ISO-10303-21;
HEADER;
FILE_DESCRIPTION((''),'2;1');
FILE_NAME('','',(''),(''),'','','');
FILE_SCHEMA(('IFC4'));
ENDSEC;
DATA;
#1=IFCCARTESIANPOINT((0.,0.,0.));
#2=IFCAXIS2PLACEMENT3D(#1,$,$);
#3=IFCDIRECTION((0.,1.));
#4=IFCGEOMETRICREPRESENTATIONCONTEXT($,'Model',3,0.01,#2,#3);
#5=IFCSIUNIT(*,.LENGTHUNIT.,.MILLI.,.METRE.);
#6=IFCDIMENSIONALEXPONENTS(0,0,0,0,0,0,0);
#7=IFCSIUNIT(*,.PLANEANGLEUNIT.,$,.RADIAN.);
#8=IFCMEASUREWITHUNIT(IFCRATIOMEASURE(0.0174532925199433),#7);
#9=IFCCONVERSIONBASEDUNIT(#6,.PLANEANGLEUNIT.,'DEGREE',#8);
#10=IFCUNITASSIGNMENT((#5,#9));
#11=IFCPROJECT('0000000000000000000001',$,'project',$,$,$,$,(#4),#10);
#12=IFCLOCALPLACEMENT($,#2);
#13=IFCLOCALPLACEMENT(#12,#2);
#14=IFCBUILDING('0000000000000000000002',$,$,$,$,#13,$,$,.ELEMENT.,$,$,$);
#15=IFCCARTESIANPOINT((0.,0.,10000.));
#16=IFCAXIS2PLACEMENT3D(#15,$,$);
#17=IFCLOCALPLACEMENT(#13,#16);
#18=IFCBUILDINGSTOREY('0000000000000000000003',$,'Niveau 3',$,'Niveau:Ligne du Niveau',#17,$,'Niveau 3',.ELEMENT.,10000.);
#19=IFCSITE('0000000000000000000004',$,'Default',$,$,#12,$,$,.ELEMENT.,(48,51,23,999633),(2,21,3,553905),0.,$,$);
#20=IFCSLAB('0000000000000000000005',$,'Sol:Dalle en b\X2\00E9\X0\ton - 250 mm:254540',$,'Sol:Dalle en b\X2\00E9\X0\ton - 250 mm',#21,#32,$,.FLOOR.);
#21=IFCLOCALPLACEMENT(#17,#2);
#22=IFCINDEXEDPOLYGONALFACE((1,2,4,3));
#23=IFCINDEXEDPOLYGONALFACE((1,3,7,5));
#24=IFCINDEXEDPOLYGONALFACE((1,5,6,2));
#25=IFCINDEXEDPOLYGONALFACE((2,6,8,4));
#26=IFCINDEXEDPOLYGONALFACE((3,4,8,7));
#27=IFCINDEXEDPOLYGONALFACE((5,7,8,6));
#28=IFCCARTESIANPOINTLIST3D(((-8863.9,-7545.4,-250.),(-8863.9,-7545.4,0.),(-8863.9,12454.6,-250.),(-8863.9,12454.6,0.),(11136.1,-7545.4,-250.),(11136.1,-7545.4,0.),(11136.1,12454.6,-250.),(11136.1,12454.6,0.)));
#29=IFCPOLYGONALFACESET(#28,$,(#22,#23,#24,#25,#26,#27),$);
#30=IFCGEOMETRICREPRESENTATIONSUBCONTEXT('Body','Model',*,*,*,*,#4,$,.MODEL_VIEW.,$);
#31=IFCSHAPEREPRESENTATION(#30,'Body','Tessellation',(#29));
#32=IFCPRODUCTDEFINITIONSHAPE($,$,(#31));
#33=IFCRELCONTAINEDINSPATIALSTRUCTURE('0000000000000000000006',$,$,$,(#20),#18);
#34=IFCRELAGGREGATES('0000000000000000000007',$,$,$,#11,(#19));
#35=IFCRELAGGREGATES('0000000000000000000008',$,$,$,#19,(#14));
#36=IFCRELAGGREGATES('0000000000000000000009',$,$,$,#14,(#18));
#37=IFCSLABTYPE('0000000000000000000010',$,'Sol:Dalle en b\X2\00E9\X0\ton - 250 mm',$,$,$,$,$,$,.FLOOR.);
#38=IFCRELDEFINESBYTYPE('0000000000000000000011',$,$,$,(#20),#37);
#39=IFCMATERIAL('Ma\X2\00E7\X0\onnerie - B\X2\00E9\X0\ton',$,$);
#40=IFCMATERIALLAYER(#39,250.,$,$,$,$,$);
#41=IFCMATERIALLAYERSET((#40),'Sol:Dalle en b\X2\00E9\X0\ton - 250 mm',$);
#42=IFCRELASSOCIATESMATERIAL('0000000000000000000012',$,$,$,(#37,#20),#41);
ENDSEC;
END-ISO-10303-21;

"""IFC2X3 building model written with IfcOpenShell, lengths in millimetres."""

from ifc_helpers import new_model, entity, si_unit, converted_unit, direction, frame, origin, origin_2d_with_axis, place, context, subcontext, project, spatial, rectangle, extrude, material, layer, layer_set, layer_usage, type_object, element, save


model = new_model("IFC2X3")

# Units and contexts
model_context = context("Model", 3, precision=0.01, world=origin(), true_north=direction((0.0, 1.0)))
body_context = subcontext(model_context, "Body", "Model", "MODEL_VIEW")
ifc_project = project(units=[si_unit("LENGTHUNIT", "METRE", prefix="MILLI"), converted_unit("PLANEANGLEUNIT", "DEGREE", entity("IfcRatioMeasure", 0.0174532925199433), si_unit("PLANEANGLEUNIT", "RADIAN"), dimensions=[0, 0, 0, 0, 0, 0, 0])], contexts=[model_context])

# Site, building, storey
site_placement = place(None, origin())
site = spatial("IfcSite", under=ifc_project, at=site_placement, Name="Default", CompositionType="ELEMENT", RefLatitude=(48, 51, 23, 999633), RefLongitude=(2, 21, 3, 553905), RefElevation=0.0)
building_placement = place(site_placement, origin())
building = spatial("IfcBuilding", under=site, at=building_placement, CompositionType="ELEMENT")
storey_placement = place(building_placement, frame((0.0, 0.0, 10000.0)))
storey = spatial("IfcBuildingStorey", under=building, at=storey_placement, Name="Niveau 3", ObjectType="Niveau:Ligne du Niveau", LongName="Niveau 3", CompositionType="ELEMENT", Elevation=10000.0)

# Slab
ifc_material = material(Name="Maçonnerie - Béton")
ifc_layer = layer(ifc_material, 250.0)
ifc_layer_set = layer_set([ifc_layer], Name="Sol:Dalle en béton - 250 mm")
ifc_layer_usage = layer_usage(ifc_layer_set, "AXIS3", "POSITIVE", 0.0)
slab_type = type_object("IfcSlabType", Name="Sol:Dalle en béton - 250 mm", PredefinedType="FLOOR", material=ifc_layer_set)
slab_placement = place(storey_placement, origin())
element("IfcSlab", 1, at=slab_placement, inside=storey, type_object=slab_type, material=ifc_layer_usage, Name="Sol:Dalle en béton - 250 mm:254540", ObjectType="Sol:Dalle en béton - 250 mm", PredefinedType="FLOOR", context=body_context, shape_type="SweptSolid", body=[
    extrude(rectangle(XDim=20000.0, YDim=20000.0, at=origin_2d_with_axis()), frame((1136.1, 2454.6, 0.0), z_axis=(0.0, 0.0, -1.0), x_axis=(0.0, 1.0, 0.0)), (0.0, 0.0, 1.0), 250.0),
])

save(model, "model.ifc")
